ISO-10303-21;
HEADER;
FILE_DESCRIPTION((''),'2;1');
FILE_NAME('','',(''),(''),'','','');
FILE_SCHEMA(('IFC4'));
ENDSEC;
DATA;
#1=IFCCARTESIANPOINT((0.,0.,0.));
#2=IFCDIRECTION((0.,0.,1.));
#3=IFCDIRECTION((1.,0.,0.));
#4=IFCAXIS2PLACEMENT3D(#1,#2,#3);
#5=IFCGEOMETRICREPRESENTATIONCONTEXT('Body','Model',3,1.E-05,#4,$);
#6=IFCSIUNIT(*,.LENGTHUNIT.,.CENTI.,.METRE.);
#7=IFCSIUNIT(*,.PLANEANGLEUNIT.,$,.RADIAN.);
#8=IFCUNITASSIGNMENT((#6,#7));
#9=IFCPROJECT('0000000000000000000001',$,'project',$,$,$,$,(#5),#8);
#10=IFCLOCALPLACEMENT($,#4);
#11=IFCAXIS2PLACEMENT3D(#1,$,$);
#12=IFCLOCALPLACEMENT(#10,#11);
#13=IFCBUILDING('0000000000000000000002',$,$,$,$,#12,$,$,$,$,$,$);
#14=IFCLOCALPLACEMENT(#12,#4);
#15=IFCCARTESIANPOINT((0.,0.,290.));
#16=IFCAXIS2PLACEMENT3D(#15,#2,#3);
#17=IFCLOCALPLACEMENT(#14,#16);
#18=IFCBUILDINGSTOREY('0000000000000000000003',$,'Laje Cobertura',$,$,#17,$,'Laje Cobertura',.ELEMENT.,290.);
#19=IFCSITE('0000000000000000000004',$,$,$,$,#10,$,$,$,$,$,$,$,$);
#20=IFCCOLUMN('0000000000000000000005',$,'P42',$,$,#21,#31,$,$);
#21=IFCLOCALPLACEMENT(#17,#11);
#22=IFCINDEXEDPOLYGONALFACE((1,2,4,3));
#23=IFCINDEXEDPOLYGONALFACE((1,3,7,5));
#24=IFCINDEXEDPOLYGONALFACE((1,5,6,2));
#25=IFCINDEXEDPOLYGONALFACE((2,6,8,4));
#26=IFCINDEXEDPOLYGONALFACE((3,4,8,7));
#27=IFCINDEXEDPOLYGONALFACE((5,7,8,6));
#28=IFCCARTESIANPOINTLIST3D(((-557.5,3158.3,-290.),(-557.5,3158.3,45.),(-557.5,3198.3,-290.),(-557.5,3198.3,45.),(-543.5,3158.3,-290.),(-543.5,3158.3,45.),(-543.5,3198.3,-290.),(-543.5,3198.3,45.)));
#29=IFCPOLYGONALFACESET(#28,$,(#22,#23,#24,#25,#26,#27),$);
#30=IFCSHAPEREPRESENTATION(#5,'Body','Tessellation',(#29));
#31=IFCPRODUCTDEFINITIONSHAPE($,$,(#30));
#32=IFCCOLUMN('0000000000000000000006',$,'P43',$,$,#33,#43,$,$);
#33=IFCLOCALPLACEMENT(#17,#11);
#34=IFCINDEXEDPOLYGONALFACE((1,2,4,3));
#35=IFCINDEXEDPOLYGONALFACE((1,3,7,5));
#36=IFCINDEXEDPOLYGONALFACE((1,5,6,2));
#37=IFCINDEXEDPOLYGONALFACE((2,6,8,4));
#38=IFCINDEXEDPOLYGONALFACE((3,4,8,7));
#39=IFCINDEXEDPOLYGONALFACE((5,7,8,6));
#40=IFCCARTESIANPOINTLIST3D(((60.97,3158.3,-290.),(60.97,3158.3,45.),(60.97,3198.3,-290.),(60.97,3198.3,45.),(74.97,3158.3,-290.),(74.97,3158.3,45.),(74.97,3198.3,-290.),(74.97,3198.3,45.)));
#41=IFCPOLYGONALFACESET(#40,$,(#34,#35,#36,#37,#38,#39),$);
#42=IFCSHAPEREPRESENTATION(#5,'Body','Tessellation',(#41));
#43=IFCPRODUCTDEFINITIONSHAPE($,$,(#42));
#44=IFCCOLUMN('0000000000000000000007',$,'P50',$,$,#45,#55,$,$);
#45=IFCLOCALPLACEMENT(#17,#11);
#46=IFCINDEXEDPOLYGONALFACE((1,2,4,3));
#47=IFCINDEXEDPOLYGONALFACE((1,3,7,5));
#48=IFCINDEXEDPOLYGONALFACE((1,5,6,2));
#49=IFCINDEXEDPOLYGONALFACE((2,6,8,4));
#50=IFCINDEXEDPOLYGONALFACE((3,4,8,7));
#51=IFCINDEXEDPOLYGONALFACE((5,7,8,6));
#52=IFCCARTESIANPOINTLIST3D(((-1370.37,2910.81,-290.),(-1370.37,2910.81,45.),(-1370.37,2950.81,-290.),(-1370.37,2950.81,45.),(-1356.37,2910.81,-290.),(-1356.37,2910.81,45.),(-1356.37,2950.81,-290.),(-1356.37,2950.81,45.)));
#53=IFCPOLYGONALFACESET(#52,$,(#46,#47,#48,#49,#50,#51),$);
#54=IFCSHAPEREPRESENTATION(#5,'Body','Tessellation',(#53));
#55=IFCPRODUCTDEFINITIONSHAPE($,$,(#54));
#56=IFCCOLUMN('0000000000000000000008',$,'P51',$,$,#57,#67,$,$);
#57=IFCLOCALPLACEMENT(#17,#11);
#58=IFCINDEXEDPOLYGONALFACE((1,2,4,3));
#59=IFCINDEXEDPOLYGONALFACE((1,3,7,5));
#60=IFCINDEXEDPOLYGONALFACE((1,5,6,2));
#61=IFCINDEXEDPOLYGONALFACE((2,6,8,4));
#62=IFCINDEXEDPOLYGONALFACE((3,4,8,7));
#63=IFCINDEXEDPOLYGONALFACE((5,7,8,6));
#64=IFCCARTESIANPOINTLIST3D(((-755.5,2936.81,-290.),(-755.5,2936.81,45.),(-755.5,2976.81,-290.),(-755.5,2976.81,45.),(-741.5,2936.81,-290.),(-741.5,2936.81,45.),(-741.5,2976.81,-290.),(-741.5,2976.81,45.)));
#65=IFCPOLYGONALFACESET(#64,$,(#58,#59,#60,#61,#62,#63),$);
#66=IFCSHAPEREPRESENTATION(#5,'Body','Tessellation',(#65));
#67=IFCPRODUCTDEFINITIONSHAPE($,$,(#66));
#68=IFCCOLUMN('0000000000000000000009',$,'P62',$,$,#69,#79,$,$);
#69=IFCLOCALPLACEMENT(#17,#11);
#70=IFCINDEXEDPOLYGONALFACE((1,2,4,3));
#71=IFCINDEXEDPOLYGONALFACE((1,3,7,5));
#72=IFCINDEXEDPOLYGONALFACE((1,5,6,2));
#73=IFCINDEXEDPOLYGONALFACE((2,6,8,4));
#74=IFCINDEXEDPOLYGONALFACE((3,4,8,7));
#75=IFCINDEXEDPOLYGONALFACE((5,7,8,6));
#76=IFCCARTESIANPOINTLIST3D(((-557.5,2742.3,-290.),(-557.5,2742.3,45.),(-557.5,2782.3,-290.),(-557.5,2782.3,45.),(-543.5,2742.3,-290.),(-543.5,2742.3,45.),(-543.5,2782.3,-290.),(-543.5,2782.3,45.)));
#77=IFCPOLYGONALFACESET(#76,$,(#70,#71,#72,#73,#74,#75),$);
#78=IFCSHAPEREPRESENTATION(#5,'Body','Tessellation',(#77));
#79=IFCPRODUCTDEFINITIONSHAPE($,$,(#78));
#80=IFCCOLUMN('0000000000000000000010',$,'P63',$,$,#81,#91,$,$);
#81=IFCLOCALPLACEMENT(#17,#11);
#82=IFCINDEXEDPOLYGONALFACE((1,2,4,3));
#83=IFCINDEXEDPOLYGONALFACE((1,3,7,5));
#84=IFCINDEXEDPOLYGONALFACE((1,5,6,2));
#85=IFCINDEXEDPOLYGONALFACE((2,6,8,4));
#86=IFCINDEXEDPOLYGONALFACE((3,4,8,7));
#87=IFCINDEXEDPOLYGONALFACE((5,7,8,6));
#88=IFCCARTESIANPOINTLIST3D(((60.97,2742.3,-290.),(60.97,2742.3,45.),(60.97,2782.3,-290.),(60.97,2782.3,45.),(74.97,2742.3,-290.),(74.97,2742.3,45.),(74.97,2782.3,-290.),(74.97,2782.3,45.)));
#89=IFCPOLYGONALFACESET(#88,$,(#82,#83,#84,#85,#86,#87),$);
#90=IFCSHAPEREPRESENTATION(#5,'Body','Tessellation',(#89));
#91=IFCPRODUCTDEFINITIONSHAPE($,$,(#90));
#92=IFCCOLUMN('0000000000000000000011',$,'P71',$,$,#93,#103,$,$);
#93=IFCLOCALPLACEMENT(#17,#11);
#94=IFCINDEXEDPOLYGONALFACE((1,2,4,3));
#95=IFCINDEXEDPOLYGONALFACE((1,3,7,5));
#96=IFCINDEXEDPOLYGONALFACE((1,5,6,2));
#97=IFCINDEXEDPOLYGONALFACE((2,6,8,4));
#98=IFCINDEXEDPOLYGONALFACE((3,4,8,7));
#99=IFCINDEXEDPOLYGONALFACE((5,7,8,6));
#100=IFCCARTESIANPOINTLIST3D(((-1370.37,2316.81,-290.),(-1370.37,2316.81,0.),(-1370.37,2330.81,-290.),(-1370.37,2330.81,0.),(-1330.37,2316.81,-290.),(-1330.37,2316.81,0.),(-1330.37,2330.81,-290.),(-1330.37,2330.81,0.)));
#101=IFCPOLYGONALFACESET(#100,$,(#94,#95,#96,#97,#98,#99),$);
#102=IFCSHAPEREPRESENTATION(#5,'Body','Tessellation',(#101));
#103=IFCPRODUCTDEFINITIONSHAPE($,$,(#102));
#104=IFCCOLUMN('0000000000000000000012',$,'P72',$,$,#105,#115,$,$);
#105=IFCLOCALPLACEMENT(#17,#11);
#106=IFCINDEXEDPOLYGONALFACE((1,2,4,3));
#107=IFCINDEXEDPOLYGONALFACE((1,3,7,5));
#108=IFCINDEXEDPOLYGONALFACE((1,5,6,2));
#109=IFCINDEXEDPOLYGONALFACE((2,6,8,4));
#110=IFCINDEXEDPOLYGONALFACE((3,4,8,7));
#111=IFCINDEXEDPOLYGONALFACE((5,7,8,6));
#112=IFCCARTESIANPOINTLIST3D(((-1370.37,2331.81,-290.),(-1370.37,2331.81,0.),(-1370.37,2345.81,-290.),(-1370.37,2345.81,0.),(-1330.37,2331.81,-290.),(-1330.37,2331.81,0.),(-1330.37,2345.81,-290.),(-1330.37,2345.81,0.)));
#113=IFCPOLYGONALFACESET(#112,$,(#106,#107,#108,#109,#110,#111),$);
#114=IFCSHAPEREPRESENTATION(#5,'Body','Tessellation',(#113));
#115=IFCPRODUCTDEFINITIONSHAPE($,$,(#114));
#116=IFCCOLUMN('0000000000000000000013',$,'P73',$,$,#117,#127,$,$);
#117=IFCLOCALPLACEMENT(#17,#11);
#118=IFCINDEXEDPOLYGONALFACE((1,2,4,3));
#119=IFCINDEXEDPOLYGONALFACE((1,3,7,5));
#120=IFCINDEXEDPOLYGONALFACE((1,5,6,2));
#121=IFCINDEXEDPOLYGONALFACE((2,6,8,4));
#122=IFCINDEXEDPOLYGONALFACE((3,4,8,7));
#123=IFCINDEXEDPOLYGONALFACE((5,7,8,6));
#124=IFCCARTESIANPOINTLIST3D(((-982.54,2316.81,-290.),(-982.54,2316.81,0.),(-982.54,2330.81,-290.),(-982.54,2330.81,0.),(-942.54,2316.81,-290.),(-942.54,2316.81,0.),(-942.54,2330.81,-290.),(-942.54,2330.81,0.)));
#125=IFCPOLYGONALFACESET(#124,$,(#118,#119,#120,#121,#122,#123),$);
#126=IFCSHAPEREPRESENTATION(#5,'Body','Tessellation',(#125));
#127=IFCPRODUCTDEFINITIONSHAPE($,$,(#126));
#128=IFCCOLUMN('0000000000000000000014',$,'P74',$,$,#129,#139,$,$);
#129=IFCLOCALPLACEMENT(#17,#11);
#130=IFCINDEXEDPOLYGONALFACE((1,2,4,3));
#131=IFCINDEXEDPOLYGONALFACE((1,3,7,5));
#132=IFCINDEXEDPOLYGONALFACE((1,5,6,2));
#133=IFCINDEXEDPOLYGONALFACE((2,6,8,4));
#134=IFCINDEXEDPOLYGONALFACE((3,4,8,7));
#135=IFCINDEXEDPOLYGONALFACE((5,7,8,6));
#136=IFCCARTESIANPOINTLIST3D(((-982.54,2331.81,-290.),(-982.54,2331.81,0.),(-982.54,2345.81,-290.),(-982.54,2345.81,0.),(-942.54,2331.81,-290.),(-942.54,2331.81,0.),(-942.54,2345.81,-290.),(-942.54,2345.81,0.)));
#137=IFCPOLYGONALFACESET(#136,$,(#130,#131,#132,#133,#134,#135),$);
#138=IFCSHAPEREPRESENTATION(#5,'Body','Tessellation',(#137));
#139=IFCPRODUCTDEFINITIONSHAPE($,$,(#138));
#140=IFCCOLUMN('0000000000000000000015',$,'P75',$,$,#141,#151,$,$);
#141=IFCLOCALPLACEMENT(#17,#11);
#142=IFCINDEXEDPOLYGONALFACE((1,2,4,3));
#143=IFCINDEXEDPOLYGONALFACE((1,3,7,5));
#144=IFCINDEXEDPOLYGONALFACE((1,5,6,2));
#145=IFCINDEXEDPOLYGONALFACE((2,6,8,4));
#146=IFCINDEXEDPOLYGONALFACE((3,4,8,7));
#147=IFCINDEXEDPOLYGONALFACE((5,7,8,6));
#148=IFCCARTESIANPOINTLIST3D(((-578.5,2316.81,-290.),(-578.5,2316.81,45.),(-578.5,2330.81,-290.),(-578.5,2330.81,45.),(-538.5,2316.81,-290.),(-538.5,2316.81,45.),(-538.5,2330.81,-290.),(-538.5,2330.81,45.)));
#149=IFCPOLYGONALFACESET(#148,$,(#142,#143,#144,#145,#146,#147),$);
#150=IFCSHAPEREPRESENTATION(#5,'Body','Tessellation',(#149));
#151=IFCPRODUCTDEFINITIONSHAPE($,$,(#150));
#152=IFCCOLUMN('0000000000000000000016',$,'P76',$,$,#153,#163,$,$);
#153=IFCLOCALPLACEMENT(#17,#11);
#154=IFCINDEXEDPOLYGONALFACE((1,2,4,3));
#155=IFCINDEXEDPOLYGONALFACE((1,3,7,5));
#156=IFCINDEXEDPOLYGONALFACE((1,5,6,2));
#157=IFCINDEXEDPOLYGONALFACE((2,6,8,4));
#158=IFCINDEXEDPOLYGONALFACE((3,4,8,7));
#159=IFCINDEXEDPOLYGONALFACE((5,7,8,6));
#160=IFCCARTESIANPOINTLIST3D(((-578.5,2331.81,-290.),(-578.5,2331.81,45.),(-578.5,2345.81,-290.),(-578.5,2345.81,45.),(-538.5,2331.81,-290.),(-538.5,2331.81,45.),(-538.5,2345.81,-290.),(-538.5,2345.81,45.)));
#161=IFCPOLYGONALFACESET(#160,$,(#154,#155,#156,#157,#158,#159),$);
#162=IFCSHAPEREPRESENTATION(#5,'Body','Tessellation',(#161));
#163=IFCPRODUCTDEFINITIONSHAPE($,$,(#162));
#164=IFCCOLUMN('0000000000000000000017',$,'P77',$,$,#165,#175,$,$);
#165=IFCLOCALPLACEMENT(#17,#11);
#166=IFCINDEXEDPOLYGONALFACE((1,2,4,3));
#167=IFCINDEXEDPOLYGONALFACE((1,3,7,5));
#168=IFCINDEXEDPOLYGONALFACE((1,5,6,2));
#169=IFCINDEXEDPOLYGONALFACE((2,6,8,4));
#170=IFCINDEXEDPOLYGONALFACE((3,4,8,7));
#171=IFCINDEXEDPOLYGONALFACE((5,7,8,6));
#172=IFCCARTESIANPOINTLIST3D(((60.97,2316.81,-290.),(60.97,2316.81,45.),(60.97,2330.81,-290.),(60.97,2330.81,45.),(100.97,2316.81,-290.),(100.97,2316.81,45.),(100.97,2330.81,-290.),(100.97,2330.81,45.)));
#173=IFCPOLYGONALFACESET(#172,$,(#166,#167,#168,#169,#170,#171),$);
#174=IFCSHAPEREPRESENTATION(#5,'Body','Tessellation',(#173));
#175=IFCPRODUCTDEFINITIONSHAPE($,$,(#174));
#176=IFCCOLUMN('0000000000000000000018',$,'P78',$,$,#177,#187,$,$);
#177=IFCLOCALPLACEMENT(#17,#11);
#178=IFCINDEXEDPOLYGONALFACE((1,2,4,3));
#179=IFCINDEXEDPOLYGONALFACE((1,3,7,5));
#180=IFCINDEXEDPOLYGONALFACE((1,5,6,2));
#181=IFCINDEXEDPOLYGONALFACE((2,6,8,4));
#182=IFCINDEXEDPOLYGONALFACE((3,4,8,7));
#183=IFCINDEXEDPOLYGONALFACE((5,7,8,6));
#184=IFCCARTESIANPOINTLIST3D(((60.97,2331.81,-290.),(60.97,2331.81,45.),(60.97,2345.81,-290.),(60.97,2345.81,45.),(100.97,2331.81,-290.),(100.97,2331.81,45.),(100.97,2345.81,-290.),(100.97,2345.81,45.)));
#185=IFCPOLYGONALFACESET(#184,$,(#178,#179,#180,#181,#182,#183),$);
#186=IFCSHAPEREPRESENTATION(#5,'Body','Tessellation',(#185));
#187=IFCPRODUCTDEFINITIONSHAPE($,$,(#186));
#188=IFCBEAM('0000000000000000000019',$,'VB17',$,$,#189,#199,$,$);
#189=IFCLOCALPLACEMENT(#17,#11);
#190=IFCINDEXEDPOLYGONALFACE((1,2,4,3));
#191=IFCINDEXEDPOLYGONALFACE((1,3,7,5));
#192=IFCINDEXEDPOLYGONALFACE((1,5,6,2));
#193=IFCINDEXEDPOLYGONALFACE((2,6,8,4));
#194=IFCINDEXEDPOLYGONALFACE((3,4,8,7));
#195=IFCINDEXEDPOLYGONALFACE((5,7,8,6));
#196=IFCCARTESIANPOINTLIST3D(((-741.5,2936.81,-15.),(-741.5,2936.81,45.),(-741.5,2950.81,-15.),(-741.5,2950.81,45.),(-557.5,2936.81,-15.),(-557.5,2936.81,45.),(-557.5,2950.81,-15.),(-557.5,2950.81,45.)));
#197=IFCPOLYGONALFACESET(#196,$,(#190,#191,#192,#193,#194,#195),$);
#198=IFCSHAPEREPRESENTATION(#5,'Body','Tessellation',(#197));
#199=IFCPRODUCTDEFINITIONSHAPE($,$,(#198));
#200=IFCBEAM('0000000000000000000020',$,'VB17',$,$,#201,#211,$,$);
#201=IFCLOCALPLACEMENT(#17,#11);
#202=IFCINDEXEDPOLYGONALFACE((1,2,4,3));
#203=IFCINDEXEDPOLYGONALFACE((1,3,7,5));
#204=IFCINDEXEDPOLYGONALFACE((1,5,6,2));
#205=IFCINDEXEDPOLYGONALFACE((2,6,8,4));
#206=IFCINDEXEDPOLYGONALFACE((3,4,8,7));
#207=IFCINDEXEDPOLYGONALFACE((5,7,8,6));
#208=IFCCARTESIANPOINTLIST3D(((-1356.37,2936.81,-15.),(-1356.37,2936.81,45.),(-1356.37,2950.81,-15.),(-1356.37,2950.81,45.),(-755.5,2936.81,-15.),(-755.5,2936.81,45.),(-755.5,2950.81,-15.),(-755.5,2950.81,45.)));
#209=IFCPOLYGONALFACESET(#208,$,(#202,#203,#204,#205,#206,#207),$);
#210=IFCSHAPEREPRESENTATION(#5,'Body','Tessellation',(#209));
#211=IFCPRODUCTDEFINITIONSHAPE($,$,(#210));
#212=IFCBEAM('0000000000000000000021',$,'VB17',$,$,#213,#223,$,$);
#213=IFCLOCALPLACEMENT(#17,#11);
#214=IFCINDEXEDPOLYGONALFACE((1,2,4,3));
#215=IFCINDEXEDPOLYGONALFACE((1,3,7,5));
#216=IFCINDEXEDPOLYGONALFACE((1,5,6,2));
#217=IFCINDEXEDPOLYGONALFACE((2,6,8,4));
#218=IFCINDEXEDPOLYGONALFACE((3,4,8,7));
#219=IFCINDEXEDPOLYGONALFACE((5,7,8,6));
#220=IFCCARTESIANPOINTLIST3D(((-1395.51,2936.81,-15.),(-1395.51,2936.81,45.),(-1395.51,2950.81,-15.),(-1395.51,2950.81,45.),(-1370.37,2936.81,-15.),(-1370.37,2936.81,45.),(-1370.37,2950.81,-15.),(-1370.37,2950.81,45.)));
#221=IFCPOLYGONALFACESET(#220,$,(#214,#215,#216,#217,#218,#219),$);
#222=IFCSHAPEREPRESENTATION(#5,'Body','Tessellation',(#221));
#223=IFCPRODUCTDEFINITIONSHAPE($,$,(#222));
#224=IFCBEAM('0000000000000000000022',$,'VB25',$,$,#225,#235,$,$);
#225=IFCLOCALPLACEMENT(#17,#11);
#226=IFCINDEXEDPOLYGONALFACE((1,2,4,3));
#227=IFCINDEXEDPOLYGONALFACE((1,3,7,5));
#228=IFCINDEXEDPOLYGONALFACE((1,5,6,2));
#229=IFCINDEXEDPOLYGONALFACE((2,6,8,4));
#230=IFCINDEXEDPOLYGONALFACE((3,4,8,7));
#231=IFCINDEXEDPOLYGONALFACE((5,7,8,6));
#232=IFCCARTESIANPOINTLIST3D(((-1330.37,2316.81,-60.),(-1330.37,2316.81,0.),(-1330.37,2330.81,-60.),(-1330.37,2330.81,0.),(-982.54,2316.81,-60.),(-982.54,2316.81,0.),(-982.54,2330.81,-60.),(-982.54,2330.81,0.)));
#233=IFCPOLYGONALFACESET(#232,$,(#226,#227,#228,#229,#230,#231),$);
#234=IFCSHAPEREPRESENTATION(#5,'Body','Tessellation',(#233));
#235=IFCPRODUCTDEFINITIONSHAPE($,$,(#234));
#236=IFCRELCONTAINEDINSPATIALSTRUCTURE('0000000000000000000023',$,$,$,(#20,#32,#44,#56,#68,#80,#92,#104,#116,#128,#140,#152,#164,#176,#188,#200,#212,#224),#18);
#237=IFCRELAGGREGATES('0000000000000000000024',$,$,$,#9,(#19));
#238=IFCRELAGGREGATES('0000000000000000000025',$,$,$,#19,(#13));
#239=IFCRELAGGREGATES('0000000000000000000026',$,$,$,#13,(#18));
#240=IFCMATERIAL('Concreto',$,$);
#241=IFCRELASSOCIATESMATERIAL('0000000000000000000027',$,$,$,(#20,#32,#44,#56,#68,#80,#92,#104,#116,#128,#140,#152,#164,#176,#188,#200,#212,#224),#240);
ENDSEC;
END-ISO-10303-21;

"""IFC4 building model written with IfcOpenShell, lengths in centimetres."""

from ifc_helpers import new_model, si_unit, frame, origin, origin_with_axes, origin_2d_with_axis, place, context, project, spatial, rectangle, extrude, material, element, save


model = new_model("IFC4")

# Units and contexts
model_context = context("Model", 3, precision=1e-05, world=origin_with_axes(), identifier="Body")
ifc_project = project(units=[si_unit("LENGTHUNIT", "METRE", prefix="CENTI"), si_unit("PLANEANGLEUNIT", "RADIAN")], contexts=[model_context])

# Site, building, storey
site_placement = place(None, origin_with_axes())
site = spatial("IfcSite", under=ifc_project, at=site_placement)
building_placement = place(site_placement, origin())
building = spatial("IfcBuilding", under=site, at=building_placement)
placement = place(building_placement, origin_with_axes())
storey_placement = place(placement, frame((0.0, 0.0, 290.0), z_axis=(0.0, 0.0, 1.0), x_axis=(1.0, 0.0, 0.0)))
storey = spatial("IfcBuildingStorey", under=building, at=storey_placement, Name="Laje Cobertura", LongName="Laje Cobertura", CompositionType="ELEMENT", Elevation=290.0)

# Columns
ifc_material = material(Name="Concreto")
for number, where, z_axis, x_axis, name in (
    (1, (-550.5, 3178.3, 45.0), (0.0, 0.0, 1.0), (1.0, 0.0, 0.0), "P42"),
    (2, (67.97, 3178.3, 45.0), (0.0, 0.0, 1.0), (1.0, 0.0, 0.0), "P43"),
    (3, (-1363.37, 2930.81, 45.0), (0.0, 0.0, 1.0), (1.0, 0.0, 0.0), "P50"),
    (4, (-748.5, 2956.81, 45.0), (0.0, 0.0, 1.0), (1.0, 0.0, 0.0), "P51"),
    (5, (-550.5, 2762.3, 45.0), (0.0, 0.0, 1.0), (1.0, 0.0, 0.0), "P62"),
    (6, (67.97, 2762.3, 45.0), (0.0, 0.0, 1.0), (1.0, 0.0, 0.0), "P63"),
):
    element("IfcColumn", number, at=place(storey_placement, frame(where, z_axis=z_axis, x_axis=x_axis)), inside=storey, material=ifc_material, Name=name, context=model_context, shape_type="SolidModel", body=[
        extrude(rectangle(XDim=14.0, YDim=40.0, at=origin_2d_with_axis()), origin_with_axes(), (0.0, 0.0, -1.0), 335.0),
    ])
for number, where, z_axis, x_axis, name in (
    (7, (-1350.37, 2323.81, 0.0), (0.0, 0.0, 1.0), (1.0, 0.0, 0.0), "P71"),
    (8, (-1350.37, 2338.81, 0.0), (0.0, 0.0, 1.0), (1.0, 0.0, 0.0), "P72"),
    (9, (-962.54, 2323.81, 0.0), (0.0, 0.0, 1.0), (1.0, 0.0, 0.0), "P73"),
    (10, (-962.54, 2338.81, 0.0), (0.0, 0.0, 1.0), (1.0, 0.0, 0.0), "P74"),
):
    element("IfcColumn", number, at=place(storey_placement, frame(where, z_axis=z_axis, x_axis=x_axis)), inside=storey, material=ifc_material, Name=name, context=model_context, shape_type="SolidModel", body=[
        extrude(rectangle(XDim=14.0, YDim=40.0, at=origin_2d_with_axis()), frame((0.0, 0.0, 0.0), z_axis=(0.0, 0.0, 1.0), x_axis=(0.0, -1.0, 0.0)), (0.0, 0.0, -1.0), 290.0),
    ])
for number, where, z_axis, x_axis, name in (
    (11, (-558.5, 2323.81, 45.0), (0.0, 0.0, 1.0), (1.0, 0.0, 0.0), "P75"),
    (12, (-558.5, 2338.81, 45.0), (0.0, 0.0, 1.0), (1.0, 0.0, 0.0), "P76"),
    (13, (80.97, 2323.81, 45.0), (0.0, 0.0, 1.0), (1.0, 0.0, 0.0), "P77"),
    (14, (80.97, 2338.81, 45.0), (0.0, 0.0, 1.0), (1.0, 0.0, 0.0), "P78"),
):
    element("IfcColumn", number, at=place(storey_placement, frame(where, z_axis=z_axis, x_axis=x_axis)), inside=storey, material=ifc_material, Name=name, context=model_context, shape_type="SolidModel", body=[
        extrude(rectangle(XDim=14.0, YDim=40.0, at=origin_2d_with_axis()), frame((0.0, 0.0, 0.0), z_axis=(0.0, 0.0, 1.0), x_axis=(0.0, -1.0, 0.0)), (0.0, 0.0, -1.0), 335.0),
    ])

# Beams
beam_1_placement = place(storey_placement, frame((-649.5, 2943.81, 45.0), z_axis=(0.0, 0.0, 1.0), x_axis=(1.0, 0.0, 0.0)))
element("IfcBeam", 15, at=beam_1_placement, inside=storey, material=ifc_material, Name="VB17", context=model_context, shape_type="SolidModel", body=[
    extrude(rectangle(XDim=14.0, YDim=60.0, at=origin_2d_with_axis()), frame((-92.0, 0.0, -30.0), z_axis=(1.0, 0.0, 0.0), x_axis=(0.0, 1.0, 0.0)), (0.0, 0.0, 1.0), 184.0),
])
beam_2_placement = place(storey_placement, frame((-1055.93, 2943.81, 45.0), z_axis=(0.0, 0.0, 1.0), x_axis=(1.0, 0.0, 0.0)))
element("IfcBeam", 16, at=beam_2_placement, inside=storey, material=ifc_material, Name="VB17", context=model_context, shape_type="SolidModel", body=[
    extrude(rectangle(XDim=14.0, YDim=60.0, at=origin_2d_with_axis()), frame((-300.44, 0.0, -30.0), z_axis=(1.0, 0.0, 0.0), x_axis=(0.0, 1.0, 0.0)), (0.0, 0.0, 1.0), 600.87),
])
beam_3_placement = place(storey_placement, frame((-1382.94, 2943.81, 45.0), z_axis=(0.0, 0.0, 1.0), x_axis=(1.0, 0.0, 0.0)))
element("IfcBeam", 17, at=beam_3_placement, inside=storey, material=ifc_material, Name="VB17", context=model_context, shape_type="SolidModel", body=[
    extrude(rectangle(XDim=14.0, YDim=60.0, at=origin_2d_with_axis()), frame((-12.57, 0.0, -30.0), z_axis=(1.0, 0.0, 0.0), x_axis=(0.0, 1.0, 0.0)), (0.0, 0.0, 1.0), 25.14),
])
beam_4_placement = place(storey_placement, frame((-1156.45, 2323.81, 0.0), z_axis=(0.0, 0.0, 1.0), x_axis=(1.0, 0.0, 0.0)))
element("IfcBeam", 18, at=beam_4_placement, inside=storey, material=ifc_material, Name="VB25", context=model_context, shape_type="SolidModel", body=[
    extrude(rectangle(XDim=14.0, YDim=60.0, at=origin_2d_with_axis()), frame((-173.91, 0.0, -30.0), z_axis=(1.0, 0.0, 0.0), x_axis=(0.0, 1.0, 0.0)), (0.0, 0.0, 1.0), 347.83),
])

save(model, "model.ifc")
